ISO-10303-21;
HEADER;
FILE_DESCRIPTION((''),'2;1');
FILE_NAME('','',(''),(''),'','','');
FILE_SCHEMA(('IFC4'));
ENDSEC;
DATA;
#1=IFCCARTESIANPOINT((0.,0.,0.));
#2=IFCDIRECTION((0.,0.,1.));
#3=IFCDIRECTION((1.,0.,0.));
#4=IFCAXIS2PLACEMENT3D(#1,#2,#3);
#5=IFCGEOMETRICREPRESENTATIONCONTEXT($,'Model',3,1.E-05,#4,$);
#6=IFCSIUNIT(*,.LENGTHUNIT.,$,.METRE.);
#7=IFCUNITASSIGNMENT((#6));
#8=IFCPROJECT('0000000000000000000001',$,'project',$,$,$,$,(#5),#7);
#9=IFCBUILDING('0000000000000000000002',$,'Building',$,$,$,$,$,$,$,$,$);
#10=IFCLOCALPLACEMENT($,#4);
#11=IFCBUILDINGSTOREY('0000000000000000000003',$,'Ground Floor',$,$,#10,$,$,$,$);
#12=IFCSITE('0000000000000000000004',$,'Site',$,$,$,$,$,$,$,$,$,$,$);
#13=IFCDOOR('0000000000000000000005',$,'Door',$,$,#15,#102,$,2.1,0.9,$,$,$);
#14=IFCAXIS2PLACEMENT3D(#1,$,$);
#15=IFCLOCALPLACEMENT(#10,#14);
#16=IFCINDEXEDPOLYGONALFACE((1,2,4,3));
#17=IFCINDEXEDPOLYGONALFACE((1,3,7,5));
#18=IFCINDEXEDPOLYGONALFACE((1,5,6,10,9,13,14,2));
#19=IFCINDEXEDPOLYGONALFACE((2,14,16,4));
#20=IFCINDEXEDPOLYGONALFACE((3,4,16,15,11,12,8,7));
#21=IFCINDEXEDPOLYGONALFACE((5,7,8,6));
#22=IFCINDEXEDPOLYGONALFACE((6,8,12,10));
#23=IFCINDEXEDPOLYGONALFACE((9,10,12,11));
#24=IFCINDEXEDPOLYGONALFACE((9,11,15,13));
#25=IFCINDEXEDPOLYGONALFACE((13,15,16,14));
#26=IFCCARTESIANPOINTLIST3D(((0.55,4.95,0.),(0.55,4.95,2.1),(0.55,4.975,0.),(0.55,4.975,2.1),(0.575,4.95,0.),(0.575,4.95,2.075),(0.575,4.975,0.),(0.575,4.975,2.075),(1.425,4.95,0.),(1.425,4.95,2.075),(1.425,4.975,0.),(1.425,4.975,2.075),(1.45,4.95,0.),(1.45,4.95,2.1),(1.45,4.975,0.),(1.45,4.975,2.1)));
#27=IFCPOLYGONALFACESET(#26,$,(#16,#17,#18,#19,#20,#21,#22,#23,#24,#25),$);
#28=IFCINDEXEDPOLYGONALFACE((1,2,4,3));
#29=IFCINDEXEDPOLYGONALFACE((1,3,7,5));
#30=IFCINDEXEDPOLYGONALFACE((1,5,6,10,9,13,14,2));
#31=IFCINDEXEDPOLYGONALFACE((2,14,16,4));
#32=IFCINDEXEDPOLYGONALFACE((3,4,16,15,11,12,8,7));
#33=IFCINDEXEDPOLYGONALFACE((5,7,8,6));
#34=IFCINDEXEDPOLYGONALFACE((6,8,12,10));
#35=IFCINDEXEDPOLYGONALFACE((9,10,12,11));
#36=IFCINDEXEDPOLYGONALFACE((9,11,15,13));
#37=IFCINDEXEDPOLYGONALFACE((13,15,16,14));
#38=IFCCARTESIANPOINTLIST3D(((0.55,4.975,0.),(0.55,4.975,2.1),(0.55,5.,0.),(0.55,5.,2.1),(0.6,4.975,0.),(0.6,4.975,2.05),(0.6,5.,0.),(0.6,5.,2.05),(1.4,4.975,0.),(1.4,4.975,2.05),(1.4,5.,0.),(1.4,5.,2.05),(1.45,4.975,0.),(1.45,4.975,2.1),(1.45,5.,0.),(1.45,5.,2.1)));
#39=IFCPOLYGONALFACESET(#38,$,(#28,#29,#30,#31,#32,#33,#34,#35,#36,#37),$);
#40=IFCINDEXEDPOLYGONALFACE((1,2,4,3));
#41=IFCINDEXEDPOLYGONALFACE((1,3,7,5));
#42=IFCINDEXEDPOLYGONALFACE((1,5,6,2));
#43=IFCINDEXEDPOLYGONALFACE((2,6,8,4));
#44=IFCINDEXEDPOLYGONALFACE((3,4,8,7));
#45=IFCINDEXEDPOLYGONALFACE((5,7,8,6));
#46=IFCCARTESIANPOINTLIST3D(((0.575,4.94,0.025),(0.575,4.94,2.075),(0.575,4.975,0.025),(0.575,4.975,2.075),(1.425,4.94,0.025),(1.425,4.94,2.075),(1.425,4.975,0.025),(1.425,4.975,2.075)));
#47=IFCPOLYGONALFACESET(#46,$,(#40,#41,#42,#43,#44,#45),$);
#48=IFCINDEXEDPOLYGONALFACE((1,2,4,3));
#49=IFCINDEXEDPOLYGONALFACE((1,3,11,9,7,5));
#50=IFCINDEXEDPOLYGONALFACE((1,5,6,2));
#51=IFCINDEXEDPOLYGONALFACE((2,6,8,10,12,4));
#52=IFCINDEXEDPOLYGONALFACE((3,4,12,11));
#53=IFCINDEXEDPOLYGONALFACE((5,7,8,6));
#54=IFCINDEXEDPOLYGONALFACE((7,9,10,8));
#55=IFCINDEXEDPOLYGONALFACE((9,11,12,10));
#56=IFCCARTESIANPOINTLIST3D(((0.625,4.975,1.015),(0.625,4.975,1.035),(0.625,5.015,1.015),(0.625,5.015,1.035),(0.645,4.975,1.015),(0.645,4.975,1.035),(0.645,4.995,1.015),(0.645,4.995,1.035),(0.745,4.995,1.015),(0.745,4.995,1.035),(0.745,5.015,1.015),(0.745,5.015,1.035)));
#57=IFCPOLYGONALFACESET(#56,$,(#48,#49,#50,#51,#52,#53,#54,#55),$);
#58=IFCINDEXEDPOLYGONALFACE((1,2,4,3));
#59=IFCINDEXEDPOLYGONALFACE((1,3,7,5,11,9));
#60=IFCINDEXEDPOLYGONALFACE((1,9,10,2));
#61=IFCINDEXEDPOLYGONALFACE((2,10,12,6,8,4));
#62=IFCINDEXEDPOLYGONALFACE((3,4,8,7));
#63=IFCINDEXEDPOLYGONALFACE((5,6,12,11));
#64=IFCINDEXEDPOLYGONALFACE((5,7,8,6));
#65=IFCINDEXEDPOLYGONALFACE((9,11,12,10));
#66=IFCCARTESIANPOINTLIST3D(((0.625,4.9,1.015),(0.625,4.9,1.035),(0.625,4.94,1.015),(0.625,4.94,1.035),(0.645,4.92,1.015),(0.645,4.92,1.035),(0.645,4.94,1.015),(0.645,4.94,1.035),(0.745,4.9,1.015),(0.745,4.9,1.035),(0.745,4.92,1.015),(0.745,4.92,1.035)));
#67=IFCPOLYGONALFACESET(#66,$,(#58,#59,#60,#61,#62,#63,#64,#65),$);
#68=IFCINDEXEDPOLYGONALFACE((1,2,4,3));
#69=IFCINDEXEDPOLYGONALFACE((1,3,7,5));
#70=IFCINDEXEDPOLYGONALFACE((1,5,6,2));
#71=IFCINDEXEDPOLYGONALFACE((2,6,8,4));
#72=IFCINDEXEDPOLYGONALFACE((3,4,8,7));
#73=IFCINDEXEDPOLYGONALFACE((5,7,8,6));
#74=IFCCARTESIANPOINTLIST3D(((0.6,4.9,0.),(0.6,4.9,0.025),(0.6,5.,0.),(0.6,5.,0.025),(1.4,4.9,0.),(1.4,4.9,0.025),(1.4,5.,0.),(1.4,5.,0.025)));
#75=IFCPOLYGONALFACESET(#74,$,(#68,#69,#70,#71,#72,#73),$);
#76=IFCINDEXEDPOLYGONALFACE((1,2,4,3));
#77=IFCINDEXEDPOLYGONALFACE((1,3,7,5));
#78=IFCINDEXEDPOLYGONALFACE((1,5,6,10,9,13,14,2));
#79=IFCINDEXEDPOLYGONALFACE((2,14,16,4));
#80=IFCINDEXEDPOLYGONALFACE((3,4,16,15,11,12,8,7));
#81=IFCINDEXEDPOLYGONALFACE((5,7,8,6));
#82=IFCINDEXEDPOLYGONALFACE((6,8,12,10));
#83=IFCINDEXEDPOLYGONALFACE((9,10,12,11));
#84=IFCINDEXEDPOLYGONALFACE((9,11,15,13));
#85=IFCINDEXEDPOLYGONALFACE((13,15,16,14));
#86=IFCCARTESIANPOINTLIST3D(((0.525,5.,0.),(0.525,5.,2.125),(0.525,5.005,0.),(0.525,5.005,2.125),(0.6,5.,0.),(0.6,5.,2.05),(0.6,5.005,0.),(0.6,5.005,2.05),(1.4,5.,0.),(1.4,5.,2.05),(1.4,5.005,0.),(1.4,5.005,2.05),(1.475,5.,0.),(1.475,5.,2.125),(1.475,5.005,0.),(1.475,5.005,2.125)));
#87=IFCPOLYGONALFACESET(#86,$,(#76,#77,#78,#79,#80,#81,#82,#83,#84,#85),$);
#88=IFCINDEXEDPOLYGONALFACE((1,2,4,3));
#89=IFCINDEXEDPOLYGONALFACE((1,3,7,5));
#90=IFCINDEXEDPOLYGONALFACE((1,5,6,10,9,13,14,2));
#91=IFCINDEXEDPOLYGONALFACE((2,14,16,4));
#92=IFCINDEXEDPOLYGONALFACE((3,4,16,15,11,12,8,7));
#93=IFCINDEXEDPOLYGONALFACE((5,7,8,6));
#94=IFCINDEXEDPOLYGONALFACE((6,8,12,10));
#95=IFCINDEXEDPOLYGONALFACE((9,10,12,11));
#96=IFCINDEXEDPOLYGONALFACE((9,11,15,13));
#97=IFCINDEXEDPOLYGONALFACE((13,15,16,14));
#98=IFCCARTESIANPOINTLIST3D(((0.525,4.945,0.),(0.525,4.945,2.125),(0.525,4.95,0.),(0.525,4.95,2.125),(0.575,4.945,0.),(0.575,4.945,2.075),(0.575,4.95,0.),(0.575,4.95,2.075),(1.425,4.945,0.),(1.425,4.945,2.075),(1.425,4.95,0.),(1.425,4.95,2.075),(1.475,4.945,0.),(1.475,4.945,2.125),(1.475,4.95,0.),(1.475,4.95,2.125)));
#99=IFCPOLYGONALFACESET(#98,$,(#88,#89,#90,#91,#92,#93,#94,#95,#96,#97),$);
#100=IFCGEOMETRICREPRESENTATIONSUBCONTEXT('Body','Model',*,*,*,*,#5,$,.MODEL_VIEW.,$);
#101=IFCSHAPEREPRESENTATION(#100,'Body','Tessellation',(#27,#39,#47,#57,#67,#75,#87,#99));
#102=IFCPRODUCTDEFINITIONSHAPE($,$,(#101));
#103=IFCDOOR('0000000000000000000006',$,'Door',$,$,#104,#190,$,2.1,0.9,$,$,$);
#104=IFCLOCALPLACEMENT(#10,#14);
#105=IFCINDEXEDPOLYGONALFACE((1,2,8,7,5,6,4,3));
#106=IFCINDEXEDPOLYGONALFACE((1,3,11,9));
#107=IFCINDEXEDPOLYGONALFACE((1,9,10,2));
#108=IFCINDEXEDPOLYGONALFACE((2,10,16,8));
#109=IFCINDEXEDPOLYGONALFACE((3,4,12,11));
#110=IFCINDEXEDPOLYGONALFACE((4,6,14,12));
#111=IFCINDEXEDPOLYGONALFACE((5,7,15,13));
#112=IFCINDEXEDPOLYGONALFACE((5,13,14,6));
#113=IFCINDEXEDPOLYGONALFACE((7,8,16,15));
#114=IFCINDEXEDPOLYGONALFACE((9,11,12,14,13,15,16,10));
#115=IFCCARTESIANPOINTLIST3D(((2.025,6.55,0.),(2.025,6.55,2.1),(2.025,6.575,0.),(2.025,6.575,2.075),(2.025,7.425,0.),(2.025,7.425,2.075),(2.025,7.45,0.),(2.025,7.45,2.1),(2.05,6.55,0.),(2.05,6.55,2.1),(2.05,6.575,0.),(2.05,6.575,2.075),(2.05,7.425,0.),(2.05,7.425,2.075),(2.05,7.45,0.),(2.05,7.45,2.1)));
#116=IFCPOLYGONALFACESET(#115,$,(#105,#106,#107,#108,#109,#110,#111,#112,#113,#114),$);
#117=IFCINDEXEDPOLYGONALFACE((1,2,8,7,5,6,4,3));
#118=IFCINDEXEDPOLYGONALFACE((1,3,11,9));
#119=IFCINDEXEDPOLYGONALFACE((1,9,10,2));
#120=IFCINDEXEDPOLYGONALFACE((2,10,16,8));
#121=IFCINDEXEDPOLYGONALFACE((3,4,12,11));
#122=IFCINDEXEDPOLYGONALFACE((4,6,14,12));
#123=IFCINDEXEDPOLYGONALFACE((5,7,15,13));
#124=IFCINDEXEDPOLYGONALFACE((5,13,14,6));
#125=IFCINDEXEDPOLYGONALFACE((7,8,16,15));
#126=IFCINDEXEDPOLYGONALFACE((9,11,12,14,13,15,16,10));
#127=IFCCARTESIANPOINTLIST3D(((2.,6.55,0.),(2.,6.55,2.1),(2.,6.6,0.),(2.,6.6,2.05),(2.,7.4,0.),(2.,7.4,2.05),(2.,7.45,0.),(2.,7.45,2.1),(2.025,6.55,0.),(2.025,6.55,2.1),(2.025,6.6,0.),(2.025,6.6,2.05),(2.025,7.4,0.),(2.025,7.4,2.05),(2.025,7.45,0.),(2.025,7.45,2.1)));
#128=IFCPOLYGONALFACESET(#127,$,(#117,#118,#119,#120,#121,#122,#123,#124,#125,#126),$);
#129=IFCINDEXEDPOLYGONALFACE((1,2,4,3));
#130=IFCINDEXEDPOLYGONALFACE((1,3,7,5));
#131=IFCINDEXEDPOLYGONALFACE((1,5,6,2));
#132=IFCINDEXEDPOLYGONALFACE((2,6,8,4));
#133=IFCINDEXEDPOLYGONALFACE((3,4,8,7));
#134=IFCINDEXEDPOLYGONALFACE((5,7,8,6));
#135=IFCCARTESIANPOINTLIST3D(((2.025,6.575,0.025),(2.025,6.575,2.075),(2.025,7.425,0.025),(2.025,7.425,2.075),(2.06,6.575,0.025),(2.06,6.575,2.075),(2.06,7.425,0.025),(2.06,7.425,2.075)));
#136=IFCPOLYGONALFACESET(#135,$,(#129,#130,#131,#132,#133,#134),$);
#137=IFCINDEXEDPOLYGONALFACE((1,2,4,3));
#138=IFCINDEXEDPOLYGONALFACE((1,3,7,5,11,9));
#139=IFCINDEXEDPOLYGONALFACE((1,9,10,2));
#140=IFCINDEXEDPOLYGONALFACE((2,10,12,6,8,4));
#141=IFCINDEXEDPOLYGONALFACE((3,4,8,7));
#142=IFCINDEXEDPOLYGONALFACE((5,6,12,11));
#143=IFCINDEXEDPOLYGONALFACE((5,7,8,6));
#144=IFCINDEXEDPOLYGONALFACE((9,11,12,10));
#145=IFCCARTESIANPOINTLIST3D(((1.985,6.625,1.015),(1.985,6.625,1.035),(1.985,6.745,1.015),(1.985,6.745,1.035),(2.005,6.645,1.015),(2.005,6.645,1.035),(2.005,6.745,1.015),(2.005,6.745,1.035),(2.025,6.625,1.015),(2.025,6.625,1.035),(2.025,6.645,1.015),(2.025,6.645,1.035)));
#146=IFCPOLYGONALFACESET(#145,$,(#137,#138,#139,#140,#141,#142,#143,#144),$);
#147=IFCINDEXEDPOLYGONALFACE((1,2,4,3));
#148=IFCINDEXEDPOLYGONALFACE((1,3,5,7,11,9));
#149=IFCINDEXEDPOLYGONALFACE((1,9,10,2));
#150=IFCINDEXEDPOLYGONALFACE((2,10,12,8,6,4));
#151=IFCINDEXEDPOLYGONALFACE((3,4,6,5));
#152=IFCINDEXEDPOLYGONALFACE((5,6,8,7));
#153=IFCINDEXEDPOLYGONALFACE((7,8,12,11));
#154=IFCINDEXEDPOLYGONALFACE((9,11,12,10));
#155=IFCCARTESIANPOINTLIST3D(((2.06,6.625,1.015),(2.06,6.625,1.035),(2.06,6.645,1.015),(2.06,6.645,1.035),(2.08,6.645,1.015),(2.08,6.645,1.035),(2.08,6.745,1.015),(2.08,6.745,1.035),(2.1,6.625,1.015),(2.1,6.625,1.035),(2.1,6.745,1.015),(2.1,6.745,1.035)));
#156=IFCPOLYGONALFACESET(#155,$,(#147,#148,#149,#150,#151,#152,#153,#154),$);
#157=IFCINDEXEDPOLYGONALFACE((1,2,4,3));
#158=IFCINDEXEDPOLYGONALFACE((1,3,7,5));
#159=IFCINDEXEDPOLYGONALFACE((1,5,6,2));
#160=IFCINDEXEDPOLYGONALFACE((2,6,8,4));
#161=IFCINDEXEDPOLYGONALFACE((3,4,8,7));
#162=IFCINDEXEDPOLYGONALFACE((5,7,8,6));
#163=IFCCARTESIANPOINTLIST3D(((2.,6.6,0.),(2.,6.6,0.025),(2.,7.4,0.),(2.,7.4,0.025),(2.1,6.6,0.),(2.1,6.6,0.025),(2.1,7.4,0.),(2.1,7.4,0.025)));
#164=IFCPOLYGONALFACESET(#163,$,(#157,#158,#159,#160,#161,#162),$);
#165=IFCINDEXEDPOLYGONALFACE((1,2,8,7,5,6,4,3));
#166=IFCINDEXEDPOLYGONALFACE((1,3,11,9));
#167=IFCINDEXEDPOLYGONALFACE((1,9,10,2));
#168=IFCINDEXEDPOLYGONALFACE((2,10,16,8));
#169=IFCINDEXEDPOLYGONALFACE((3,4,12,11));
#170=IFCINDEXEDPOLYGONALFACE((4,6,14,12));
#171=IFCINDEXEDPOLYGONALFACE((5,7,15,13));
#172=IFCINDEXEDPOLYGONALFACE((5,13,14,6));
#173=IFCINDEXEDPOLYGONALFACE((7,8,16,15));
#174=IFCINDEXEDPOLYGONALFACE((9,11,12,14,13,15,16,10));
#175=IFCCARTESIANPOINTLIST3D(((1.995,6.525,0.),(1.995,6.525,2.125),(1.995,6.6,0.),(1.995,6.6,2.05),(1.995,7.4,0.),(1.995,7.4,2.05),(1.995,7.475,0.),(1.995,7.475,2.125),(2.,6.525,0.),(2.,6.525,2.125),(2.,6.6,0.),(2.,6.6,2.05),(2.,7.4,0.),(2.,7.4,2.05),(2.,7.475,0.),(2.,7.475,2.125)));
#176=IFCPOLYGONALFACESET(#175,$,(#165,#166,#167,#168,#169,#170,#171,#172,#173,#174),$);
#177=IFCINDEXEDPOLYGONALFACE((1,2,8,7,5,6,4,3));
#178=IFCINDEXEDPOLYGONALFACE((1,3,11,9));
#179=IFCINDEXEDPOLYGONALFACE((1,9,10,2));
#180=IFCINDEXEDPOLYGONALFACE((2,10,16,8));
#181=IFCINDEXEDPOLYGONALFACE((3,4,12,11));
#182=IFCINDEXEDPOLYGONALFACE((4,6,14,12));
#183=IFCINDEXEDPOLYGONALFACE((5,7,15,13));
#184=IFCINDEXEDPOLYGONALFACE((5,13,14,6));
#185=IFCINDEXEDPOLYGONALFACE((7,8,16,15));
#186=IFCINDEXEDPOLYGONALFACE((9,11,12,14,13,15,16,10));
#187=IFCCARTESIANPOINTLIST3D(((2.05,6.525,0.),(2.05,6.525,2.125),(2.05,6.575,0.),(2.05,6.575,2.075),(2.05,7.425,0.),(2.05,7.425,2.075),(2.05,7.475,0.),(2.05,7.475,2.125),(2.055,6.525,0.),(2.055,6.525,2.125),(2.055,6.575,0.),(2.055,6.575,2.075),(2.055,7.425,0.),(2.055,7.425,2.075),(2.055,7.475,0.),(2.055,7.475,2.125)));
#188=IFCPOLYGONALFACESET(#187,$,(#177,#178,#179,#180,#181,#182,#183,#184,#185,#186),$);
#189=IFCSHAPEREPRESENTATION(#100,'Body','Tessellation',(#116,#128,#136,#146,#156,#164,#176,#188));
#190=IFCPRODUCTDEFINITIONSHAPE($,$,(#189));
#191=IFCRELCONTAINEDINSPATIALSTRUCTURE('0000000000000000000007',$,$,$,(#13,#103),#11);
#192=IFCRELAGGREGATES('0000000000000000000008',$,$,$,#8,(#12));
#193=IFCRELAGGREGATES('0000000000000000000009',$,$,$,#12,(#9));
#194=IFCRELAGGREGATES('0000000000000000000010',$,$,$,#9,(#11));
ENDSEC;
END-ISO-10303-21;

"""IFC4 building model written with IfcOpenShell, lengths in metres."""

from ifc_helpers import new_model, si_unit, frame, origin_with_axes, place, context, subcontext, project, spatial, line, indexed_curve, outline, extrude, element, save


model = new_model("IFC4")

# Units and contexts
model_context = context("Model", 3, precision=1e-05, world=origin_with_axes())
body_context = subcontext(model_context, "Body", "Model", "MODEL_VIEW")
ifc_project = project(units=[si_unit("LENGTHUNIT", "METRE")], contexts=[model_context])

# Site, building, storey
site = spatial("IfcSite", under=ifc_project, Name="Site")
building = spatial("IfcBuilding", under=site, Name="Building")
storey_placement = place(None, origin_with_axes())
storey = spatial("IfcBuildingStorey", under=building, at=storey_placement, Name="Ground Floor")

# Doors
door_1_placement = place(storey_placement, frame((1.45, 5.0, 0.0), z_axis=(0.0, 0.0, 1.0), x_axis=(-1.0, 0.0, 0.0)))
element("IfcDoor", 1, at=door_1_placement, inside=storey, Name="Door", OverallHeight=2.1, OverallWidth=0.9, context=body_context, shape_type="SweptSolid", body=[
    extrude(outline(indexed_curve([(0.0, 0.0), (0.0, 2.1), (0.9, 2.1), (0.9, 0.0), (0.875, 0.0), (0.875, 2.075), (0.025, 2.075), (0.025, 0.0)], segments=[line(1, 2, 3, 4, 5, 6, 7, 8, 1)])), frame((0.0, 0.025, 0.0), z_axis=(0.0, -1.0, 0.0), x_axis=(1.0, 0.0, 0.0)), (0.0, 0.0, -1.0), 0.025),
    extrude(outline(indexed_curve([(0.0, 0.0), (0.0, 2.1), (0.9, 2.1), (0.9, 0.0), (0.85, 0.0), (0.85, 2.05), (0.05, 2.05), (0.05, 0.0)], segments=[line(1, 2, 3, 4, 5, 6, 7, 8, 1)])), frame((0.0, 0.0, 0.0), z_axis=(0.0, -1.0, 0.0), x_axis=(1.0, 0.0, 0.0)), (0.0, 0.0, -1.0), 0.025),
    extrude(outline(indexed_curve([(0.0, 0.0), (0.85, 0.0), (0.85, 0.035), (0.0, 0.035)], segments=[line(1, 2, 3, 4, 1)])), frame((0.025, 0.025, 0.025), z_axis=(0.0, 0.0, 1.0), x_axis=(1.0, 0.0, 0.0)), (0.0, 0.0, 1.0), 2.05),
    extrude(outline(indexed_curve([(0.0, 0.0), (0.0, -0.04), (-0.12, -0.04), (-0.12, -0.02), (-0.02, -0.02), (-0.02, 0.0)], segments=[line(1, 2, 3, 4, 5, 6, 1)])), frame((0.825, 0.025, 1.015), z_axis=(0.0, 0.0, 1.0), x_axis=(1.0, 0.0, 0.0)), (0.0, 0.0, 1.0), 0.02),
    extrude(outline(indexed_curve([(0.0, 0.0), (0.0, 0.04), (-0.12, 0.04), (-0.12, 0.02), (-0.02, 0.02), (-0.02, 0.0)], segments=[line(1, 2, 3, 4, 5, 6, 1)])), frame((0.825, 0.06, 1.015), z_axis=(0.0, 0.0, 1.0), x_axis=(1.0, 0.0, 0.0)), (0.0, 0.0, 1.0), 0.02),
    extrude(outline(indexed_curve([(0.0, 0.0), (0.8, 0.0), (0.8, 0.1), (0.0, 0.1)], segments=[line(1, 2, 3, 4, 1)])), frame((0.05, 0.0, 0.0), z_axis=(0.0, 0.0, 1.0), x_axis=(1.0, 0.0, 0.0)), (0.0, 0.0, 1.0), 0.025),
    extrude(outline(indexed_curve([(0.0, 0.0), (0.0, 2.125), (0.95, 2.125), (0.95, 0.0), (0.875, 0.0), (0.875, 2.05), (0.075, 2.05), (0.075, 0.0)], segments=[line(1, 2, 3, 4, 5, 6, 7, 8, 1)])), frame((-0.025, -0.005, 0.0), z_axis=(0.0, -1.0, 0.0), x_axis=(1.0, 0.0, 0.0)), (0.0, 0.0, -1.0), 0.005),
    extrude(outline(indexed_curve([(0.0, 0.0), (0.0, 2.125), (0.95, 2.125), (0.95, 0.0), (0.9, 0.0), (0.9, 2.075), (0.05, 2.075), (0.05, 0.0)], segments=[line(1, 2, 3, 4, 5, 6, 7, 8, 1)])), frame((-0.025, 0.05, 0.0), z_axis=(0.0, -1.0, 0.0), x_axis=(1.0, 0.0, 0.0)), (0.0, 0.0, -1.0), 0.005),
])
door_2_placement = place(storey_placement, frame((2.0, 7.45, 0.0), z_axis=(0.0, 0.0, 1.0), x_axis=(0.0, -1.0, 0.0)))
element("IfcDoor", 2, at=door_2_placement, inside=storey, Name="Door", OverallHeight=2.1, OverallWidth=0.9, context=body_context, shape_type="SweptSolid", body=[
    extrude(outline(indexed_curve([(0.0, 0.0), (0.0, 2.1), (0.9, 2.1), (0.9, 0.0), (0.875, 0.0), (0.875, 2.075), (0.025, 2.075), (0.025, 0.0)], segments=[line(1, 2, 3, 4, 5, 6, 7, 8, 1)])), frame((0.0, 0.025, 0.0), z_axis=(0.0, -1.0, 0.0), x_axis=(1.0, 0.0, 0.0)), (0.0, 0.0, -1.0), 0.025),
    extrude(outline(indexed_curve([(0.0, 0.0), (0.0, 2.1), (0.9, 2.1), (0.9, 0.0), (0.85, 0.0), (0.85, 2.05), (0.05, 2.05), (0.05, 0.0)], segments=[line(1, 2, 3, 4, 5, 6, 7, 8, 1)])), frame((0.0, 0.0, 0.0), z_axis=(0.0, -1.0, 0.0), x_axis=(1.0, 0.0, 0.0)), (0.0, 0.0, -1.0), 0.025),
    extrude(outline(indexed_curve([(0.0, 0.0), (0.85, 0.0), (0.85, 0.035), (0.0, 0.035)], segments=[line(1, 2, 3, 4, 1)])), frame((0.025, 0.025, 0.025), z_axis=(0.0, 0.0, 1.0), x_axis=(1.0, 0.0, 0.0)), (0.0, 0.0, 1.0), 2.05),
    extrude(outline(indexed_curve([(0.0, 0.0), (0.0, -0.04), (-0.12, -0.04), (-0.12, -0.02), (-0.02, -0.02), (-0.02, 0.0)], segments=[line(1, 2, 3, 4, 5, 6, 1)])), frame((0.825, 0.025, 1.015), z_axis=(0.0, 0.0, 1.0), x_axis=(1.0, 0.0, 0.0)), (0.0, 0.0, 1.0), 0.02),
    extrude(outline(indexed_curve([(0.0, 0.0), (0.0, 0.04), (-0.12, 0.04), (-0.12, 0.02), (-0.02, 0.02), (-0.02, 0.0)], segments=[line(1, 2, 3, 4, 5, 6, 1)])), frame((0.825, 0.06, 1.015), z_axis=(0.0, 0.0, 1.0), x_axis=(1.0, 0.0, 0.0)), (0.0, 0.0, 1.0), 0.02),
    extrude(outline(indexed_curve([(0.0, 0.0), (0.8, 0.0), (0.8, 0.1), (0.0, 0.1)], segments=[line(1, 2, 3, 4, 1)])), frame((0.05, 0.0, 0.0), z_axis=(0.0, 0.0, 1.0), x_axis=(1.0, 0.0, 0.0)), (0.0, 0.0, 1.0), 0.025),
    extrude(outline(indexed_curve([(0.0, 0.0), (0.0, 2.125), (0.95, 2.125), (0.95, 0.0), (0.875, 0.0), (0.875, 2.05), (0.075, 2.05), (0.075, 0.0)], segments=[line(1, 2, 3, 4, 5, 6, 7, 8, 1)])), frame((-0.025, -0.005, 0.0), z_axis=(0.0, -1.0, 0.0), x_axis=(1.0, 0.0, 0.0)), (0.0, 0.0, -1.0), 0.005),
    extrude(outline(indexed_curve([(0.0, 0.0), (0.0, 2.125), (0.95, 2.125), (0.95, 0.0), (0.9, 0.0), (0.9, 2.075), (0.05, 2.075), (0.05, 0.0)], segments=[line(1, 2, 3, 4, 5, 6, 7, 8, 1)])), frame((-0.025, 0.05, 0.0), z_axis=(0.0, -1.0, 0.0), x_axis=(1.0, 0.0, 0.0)), (0.0, 0.0, -1.0), 0.005),
])

save(model, "model.ifc")
